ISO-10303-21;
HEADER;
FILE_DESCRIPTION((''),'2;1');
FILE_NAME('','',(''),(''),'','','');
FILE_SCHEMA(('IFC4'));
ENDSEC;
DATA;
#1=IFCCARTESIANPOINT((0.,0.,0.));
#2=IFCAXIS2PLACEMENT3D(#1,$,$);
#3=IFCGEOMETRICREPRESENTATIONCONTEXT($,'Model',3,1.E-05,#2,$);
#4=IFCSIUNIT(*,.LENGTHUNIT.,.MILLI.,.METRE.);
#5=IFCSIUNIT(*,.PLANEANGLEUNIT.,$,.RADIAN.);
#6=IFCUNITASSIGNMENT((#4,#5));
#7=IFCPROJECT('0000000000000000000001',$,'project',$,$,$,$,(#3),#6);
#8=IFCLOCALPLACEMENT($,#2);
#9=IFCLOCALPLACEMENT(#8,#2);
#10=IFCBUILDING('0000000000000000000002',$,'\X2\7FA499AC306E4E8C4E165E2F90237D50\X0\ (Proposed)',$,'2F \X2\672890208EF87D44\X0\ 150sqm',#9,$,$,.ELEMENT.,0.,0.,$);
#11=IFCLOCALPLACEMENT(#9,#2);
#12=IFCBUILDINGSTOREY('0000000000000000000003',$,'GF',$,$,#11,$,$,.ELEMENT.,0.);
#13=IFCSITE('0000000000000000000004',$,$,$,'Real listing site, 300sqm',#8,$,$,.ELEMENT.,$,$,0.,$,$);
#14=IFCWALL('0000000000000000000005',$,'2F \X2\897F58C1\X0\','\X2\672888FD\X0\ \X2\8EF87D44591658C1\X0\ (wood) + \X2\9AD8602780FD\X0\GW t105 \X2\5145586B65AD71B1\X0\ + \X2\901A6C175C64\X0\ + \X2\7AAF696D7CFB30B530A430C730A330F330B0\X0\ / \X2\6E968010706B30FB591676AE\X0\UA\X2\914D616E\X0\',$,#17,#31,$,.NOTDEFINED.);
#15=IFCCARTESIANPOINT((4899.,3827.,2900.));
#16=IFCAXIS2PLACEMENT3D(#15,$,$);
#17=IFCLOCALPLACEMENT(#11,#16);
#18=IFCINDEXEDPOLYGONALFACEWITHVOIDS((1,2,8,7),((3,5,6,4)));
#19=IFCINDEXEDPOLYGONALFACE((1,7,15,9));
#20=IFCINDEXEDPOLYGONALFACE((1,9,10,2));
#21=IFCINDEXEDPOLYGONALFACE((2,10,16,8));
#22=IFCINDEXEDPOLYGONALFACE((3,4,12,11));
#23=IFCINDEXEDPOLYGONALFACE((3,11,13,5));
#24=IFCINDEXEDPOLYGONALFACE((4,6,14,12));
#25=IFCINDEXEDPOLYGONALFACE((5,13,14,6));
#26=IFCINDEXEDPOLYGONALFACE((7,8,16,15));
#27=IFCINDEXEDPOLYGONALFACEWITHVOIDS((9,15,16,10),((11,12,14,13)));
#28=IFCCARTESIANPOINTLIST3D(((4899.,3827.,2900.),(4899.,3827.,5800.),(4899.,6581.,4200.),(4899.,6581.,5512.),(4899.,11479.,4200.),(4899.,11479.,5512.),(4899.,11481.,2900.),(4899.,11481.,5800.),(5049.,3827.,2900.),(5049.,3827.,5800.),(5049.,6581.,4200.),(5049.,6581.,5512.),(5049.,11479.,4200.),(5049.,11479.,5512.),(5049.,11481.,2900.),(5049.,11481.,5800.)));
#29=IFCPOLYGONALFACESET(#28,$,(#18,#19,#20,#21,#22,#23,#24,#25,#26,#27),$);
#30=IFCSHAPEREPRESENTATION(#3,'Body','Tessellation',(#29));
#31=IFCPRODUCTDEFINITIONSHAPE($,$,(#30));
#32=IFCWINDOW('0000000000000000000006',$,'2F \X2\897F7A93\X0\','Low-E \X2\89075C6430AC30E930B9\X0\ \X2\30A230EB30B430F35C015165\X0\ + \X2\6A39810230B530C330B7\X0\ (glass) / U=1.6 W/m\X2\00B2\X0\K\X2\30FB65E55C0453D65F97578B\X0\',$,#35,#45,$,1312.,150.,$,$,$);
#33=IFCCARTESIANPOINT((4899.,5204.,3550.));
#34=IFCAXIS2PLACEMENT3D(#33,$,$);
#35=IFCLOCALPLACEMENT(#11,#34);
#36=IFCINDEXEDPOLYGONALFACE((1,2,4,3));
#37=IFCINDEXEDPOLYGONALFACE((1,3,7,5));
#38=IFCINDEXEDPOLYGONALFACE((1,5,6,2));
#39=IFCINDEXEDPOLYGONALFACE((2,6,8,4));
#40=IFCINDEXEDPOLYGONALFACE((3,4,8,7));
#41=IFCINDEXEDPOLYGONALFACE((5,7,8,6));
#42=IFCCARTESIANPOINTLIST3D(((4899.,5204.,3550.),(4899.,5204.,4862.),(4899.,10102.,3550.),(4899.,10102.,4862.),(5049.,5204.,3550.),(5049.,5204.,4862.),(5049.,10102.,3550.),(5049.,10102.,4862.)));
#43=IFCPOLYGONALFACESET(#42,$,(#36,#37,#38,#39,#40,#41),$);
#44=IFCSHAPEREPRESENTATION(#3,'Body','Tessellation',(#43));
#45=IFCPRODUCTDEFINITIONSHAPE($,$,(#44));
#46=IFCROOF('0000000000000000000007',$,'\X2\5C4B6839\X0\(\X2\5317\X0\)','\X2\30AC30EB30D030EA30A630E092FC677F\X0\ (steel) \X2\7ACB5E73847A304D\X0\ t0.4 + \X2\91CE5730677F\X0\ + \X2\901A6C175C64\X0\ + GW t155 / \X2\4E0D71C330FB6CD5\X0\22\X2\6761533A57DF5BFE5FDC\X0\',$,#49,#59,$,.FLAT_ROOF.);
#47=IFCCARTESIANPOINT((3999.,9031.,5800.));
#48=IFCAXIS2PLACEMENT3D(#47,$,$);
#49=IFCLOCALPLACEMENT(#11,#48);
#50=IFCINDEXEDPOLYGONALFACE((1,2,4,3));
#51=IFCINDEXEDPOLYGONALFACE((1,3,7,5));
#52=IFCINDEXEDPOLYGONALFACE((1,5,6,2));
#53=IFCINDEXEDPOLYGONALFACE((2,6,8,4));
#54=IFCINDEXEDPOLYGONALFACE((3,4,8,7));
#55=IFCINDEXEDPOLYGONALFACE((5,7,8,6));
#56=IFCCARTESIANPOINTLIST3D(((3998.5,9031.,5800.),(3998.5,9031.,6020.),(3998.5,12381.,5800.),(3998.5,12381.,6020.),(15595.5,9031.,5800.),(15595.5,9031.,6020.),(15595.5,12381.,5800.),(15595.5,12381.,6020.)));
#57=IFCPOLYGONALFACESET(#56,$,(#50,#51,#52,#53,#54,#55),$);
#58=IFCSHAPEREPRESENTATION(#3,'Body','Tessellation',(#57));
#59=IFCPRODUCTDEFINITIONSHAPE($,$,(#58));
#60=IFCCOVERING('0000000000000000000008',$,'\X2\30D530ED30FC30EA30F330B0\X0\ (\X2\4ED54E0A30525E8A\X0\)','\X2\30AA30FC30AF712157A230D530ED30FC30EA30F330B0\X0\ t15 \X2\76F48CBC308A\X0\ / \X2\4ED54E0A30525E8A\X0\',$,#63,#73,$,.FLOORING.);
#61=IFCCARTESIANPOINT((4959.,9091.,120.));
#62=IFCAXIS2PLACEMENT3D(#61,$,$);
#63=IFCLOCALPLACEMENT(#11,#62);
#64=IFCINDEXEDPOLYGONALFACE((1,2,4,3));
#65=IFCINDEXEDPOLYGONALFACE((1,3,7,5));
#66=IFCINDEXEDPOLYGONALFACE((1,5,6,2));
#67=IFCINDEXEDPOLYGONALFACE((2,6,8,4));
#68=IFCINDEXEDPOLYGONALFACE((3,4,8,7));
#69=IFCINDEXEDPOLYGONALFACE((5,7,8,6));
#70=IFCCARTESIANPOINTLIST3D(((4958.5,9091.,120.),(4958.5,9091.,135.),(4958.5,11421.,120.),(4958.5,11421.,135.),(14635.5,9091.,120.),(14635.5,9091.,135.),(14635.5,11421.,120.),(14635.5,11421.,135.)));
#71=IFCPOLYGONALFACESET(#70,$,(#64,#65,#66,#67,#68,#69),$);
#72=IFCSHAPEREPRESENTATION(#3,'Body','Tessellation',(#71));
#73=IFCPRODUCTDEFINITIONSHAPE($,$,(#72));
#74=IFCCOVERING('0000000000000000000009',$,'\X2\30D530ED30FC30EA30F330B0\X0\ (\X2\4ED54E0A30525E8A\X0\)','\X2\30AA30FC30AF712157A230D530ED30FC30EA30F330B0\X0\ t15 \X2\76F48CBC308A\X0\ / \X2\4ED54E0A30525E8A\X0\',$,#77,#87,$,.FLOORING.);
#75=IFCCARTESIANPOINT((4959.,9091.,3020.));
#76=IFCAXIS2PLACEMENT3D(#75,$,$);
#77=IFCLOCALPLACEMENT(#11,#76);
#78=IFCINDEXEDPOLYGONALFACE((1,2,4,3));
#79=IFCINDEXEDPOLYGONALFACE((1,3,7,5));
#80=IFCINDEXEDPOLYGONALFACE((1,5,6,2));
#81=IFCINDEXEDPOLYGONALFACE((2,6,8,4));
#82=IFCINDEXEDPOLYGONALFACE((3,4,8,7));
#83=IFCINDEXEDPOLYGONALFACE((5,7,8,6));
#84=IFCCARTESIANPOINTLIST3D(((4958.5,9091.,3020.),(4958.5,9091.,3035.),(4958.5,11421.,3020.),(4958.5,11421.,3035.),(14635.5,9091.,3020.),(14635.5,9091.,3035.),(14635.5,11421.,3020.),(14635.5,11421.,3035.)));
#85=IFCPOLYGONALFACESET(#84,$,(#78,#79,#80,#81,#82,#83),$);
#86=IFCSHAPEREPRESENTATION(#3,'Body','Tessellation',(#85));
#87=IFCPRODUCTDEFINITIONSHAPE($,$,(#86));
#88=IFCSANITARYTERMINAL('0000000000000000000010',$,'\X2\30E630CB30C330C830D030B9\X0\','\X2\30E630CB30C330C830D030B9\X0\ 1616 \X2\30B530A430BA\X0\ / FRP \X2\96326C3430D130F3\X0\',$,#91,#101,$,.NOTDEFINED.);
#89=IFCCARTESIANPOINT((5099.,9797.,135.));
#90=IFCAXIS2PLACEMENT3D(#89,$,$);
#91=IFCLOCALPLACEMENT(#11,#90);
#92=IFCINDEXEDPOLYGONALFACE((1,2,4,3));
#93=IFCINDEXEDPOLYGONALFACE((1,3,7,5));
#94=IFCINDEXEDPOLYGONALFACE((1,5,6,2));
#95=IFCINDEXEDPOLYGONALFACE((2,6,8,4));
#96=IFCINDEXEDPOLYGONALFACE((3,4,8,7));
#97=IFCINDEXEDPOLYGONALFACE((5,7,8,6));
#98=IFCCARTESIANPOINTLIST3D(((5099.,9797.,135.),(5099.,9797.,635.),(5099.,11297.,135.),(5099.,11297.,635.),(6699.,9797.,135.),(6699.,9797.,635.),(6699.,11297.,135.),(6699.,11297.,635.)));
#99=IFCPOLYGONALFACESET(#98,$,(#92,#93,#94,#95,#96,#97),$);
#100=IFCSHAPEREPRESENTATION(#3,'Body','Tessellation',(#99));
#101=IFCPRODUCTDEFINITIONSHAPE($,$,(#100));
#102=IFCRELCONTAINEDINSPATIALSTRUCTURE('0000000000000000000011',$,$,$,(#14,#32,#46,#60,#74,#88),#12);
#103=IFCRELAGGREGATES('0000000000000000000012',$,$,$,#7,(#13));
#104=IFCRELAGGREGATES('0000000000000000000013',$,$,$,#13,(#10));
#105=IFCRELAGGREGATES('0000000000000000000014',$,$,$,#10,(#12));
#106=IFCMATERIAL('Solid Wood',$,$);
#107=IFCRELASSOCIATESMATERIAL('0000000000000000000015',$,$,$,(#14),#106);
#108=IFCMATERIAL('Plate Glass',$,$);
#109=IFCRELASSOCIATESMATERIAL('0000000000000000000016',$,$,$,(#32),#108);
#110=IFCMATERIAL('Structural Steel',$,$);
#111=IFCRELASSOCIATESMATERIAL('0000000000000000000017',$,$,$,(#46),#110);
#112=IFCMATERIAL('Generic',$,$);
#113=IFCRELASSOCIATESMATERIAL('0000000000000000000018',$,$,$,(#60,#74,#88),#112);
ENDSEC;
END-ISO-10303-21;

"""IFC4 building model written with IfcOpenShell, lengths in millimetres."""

from ifc_helpers import new_model, si_unit, frame, frame_2d, origin, place, context, project, spatial, rectangle, extrude, material, element, fill, save


model = new_model("IFC4")

# Units and contexts
model_context = context("Model", 3, precision=1e-05, world=origin())
ifc_project = project(units=[si_unit("LENGTHUNIT", "METRE", prefix="MILLI"), si_unit("PLANEANGLEUNIT", "RADIAN")], contexts=[model_context])

# Site, building, storey
site_placement = place(None, origin())
site = spatial("IfcSite", under=ifc_project, at=site_placement, ObjectType="Real listing site, 300sqm", CompositionType="ELEMENT", RefElevation=0.0)
building_placement = place(site_placement, origin())
building = spatial("IfcBuilding", under=site, at=building_placement, Name="群馬の二世帯連結 (Proposed)", ObjectType="2F 木造軸組 150sqm", CompositionType="ELEMENT", ElevationOfRefHeight=0.0, ElevationOfTerrain=0.0)
storey_placement = place(building_placement, origin())
storey = spatial("IfcBuildingStorey", under=building, at=storey_placement, Name="GF", CompositionType="ELEMENT", Elevation=0.0)

# Shared definitions
ifc_material_1 = material(Name="Solid Wood")

# Shared definitions
ifc_material_2 = material(Name="Plate Glass")

# Wall, opening, window
wall_1_placement = place(storey_placement, frame((4899.0, 3827.0, 2900.0)))
wall_1 = element("IfcWall", 1, at=wall_1_placement, inside=storey, material=ifc_material_1, Name="2F 西壁", Description="木製 軸組外壁 (wood) + 高性能GW t105 充填断熱 + 通気層 + 窯業系サイディング / 準耐火・外皮UA配慮", PredefinedType="NOTDEFINED", context=model_context, shape_type="SweptSolid", body=[
    extrude(rectangle(XDim=150.0, YDim=7654.0, at=frame_2d((75.0, 3827.0))), frame((4899.0, 3827.0, 2900.0)), (0.0, 0.0, 1.0), 2900.0),
])
opening_1_placement = place(storey_placement, frame((4899.0, 5204.0, 3550.0)))
opening_1 = element("IfcOpeningElement", 2, at=opening_1_placement, cuts=wall_1, PredefinedType="NOTDEFINED", context=model_context, shape_type="SweptSolid", body=[
    extrude(rectangle(XDim=150.0, YDim=4898.0, at=frame_2d((75.0, 2449.0))), frame((4899.0, 5204.0, 3550.0)), (0.0, 0.0, 1.0), 1312.0),
])
window_1_placement = place(storey_placement, frame((4899.0, 5204.0, 3550.0)))
window_1 = element("IfcWindow", 3, at=window_1_placement, inside=storey, material=ifc_material_2, Name="2F 西窓", Description="Low-E 複層ガラス アルゴン封入 + 樹脂サッシ (glass) / U=1.6 W/m²K・日射取得型", OverallHeight=1312.0, OverallWidth=150.0, context=model_context, shape_type="SweptSolid", body=[
    extrude(rectangle(XDim=150.0, YDim=4898.0, at=frame_2d((75.0, 2449.0))), frame((4899.0, 5204.0, 3550.0)), (0.0, 0.0, 1.0), 1312.0),
])
fill(opening_1, window_1)

# Roof
ifc_material_3 = material(Name="Structural Steel")
roof_1_placement = place(storey_placement, frame((3999.0, 9031.0, 5800.0)))
element("IfcRoof", 4, at=roof_1_placement, inside=storey, material=ifc_material_3, Name="屋根(北)", Description="ガルバリウム鋼板 (steel) 立平葺き t0.4 + 野地板 + 通気層 + GW t155 / 不燃・法22条区域対応", PredefinedType="FLAT_ROOF", context=model_context, shape_type="SweptSolid", body=[
    extrude(rectangle(XDim=11597.0, YDim=3350.0, at=frame_2d((5798.0, 1675.0))), frame((3999.0, 9031.0, 5800.0)), (0.0, 0.0, 1.0), 220.0),
])

# Coverings
ifc_material_4 = material(Name="Generic")
covering_1_placement = place(storey_placement, frame((4959.0, 9091.0, 120.0)))
element("IfcCovering", 5, at=covering_1_placement, inside=storey, material=ifc_material_4, Name="フローリング (仕上げ床)", Description="オーク無垢フローリング t15 直貼り / 仕上げ床", PredefinedType="FLOORING", context=model_context, shape_type="SweptSolid", body=[
    extrude(rectangle(XDim=9677.0, YDim=2330.0, at=frame_2d((4838.0, 1165.0))), frame((4959.0, 9091.0, 120.0)), (0.0, 0.0, 1.0), 15.0),
])
covering_2_placement = place(storey_placement, frame((4959.0, 9091.0, 3020.0)))
element("IfcCovering", 6, at=covering_2_placement, inside=storey, material=ifc_material_4, Name="フローリング (仕上げ床)", Description="オーク無垢フローリング t15 直貼り / 仕上げ床", PredefinedType="FLOORING", context=model_context, shape_type="SweptSolid", body=[
    extrude(rectangle(XDim=9677.0, YDim=2330.0, at=frame_2d((4838.0, 1165.0))), frame((4959.0, 9091.0, 3020.0)), (0.0, 0.0, 1.0), 15.0),
])

# Sanitary terminal
sanitary_terminal_placement = place(storey_placement, frame((5099.0, 9797.0, 135.0)))
element("IfcSanitaryTerminal", 7, at=sanitary_terminal_placement, inside=storey, material=ifc_material_4, Name="ユニットバス", Description="ユニットバス 1616 サイズ / FRP 防水パン", PredefinedType="NOTDEFINED", context=model_context, shape_type="SweptSolid", body=[
    extrude(rectangle(XDim=1600.0, YDim=1500.0, at=frame_2d((800.0, 750.0))), frame((5099.0, 9797.0, 135.0)), (0.0, 0.0, 1.0), 500.0),
])

save(model, "model.ifc")
